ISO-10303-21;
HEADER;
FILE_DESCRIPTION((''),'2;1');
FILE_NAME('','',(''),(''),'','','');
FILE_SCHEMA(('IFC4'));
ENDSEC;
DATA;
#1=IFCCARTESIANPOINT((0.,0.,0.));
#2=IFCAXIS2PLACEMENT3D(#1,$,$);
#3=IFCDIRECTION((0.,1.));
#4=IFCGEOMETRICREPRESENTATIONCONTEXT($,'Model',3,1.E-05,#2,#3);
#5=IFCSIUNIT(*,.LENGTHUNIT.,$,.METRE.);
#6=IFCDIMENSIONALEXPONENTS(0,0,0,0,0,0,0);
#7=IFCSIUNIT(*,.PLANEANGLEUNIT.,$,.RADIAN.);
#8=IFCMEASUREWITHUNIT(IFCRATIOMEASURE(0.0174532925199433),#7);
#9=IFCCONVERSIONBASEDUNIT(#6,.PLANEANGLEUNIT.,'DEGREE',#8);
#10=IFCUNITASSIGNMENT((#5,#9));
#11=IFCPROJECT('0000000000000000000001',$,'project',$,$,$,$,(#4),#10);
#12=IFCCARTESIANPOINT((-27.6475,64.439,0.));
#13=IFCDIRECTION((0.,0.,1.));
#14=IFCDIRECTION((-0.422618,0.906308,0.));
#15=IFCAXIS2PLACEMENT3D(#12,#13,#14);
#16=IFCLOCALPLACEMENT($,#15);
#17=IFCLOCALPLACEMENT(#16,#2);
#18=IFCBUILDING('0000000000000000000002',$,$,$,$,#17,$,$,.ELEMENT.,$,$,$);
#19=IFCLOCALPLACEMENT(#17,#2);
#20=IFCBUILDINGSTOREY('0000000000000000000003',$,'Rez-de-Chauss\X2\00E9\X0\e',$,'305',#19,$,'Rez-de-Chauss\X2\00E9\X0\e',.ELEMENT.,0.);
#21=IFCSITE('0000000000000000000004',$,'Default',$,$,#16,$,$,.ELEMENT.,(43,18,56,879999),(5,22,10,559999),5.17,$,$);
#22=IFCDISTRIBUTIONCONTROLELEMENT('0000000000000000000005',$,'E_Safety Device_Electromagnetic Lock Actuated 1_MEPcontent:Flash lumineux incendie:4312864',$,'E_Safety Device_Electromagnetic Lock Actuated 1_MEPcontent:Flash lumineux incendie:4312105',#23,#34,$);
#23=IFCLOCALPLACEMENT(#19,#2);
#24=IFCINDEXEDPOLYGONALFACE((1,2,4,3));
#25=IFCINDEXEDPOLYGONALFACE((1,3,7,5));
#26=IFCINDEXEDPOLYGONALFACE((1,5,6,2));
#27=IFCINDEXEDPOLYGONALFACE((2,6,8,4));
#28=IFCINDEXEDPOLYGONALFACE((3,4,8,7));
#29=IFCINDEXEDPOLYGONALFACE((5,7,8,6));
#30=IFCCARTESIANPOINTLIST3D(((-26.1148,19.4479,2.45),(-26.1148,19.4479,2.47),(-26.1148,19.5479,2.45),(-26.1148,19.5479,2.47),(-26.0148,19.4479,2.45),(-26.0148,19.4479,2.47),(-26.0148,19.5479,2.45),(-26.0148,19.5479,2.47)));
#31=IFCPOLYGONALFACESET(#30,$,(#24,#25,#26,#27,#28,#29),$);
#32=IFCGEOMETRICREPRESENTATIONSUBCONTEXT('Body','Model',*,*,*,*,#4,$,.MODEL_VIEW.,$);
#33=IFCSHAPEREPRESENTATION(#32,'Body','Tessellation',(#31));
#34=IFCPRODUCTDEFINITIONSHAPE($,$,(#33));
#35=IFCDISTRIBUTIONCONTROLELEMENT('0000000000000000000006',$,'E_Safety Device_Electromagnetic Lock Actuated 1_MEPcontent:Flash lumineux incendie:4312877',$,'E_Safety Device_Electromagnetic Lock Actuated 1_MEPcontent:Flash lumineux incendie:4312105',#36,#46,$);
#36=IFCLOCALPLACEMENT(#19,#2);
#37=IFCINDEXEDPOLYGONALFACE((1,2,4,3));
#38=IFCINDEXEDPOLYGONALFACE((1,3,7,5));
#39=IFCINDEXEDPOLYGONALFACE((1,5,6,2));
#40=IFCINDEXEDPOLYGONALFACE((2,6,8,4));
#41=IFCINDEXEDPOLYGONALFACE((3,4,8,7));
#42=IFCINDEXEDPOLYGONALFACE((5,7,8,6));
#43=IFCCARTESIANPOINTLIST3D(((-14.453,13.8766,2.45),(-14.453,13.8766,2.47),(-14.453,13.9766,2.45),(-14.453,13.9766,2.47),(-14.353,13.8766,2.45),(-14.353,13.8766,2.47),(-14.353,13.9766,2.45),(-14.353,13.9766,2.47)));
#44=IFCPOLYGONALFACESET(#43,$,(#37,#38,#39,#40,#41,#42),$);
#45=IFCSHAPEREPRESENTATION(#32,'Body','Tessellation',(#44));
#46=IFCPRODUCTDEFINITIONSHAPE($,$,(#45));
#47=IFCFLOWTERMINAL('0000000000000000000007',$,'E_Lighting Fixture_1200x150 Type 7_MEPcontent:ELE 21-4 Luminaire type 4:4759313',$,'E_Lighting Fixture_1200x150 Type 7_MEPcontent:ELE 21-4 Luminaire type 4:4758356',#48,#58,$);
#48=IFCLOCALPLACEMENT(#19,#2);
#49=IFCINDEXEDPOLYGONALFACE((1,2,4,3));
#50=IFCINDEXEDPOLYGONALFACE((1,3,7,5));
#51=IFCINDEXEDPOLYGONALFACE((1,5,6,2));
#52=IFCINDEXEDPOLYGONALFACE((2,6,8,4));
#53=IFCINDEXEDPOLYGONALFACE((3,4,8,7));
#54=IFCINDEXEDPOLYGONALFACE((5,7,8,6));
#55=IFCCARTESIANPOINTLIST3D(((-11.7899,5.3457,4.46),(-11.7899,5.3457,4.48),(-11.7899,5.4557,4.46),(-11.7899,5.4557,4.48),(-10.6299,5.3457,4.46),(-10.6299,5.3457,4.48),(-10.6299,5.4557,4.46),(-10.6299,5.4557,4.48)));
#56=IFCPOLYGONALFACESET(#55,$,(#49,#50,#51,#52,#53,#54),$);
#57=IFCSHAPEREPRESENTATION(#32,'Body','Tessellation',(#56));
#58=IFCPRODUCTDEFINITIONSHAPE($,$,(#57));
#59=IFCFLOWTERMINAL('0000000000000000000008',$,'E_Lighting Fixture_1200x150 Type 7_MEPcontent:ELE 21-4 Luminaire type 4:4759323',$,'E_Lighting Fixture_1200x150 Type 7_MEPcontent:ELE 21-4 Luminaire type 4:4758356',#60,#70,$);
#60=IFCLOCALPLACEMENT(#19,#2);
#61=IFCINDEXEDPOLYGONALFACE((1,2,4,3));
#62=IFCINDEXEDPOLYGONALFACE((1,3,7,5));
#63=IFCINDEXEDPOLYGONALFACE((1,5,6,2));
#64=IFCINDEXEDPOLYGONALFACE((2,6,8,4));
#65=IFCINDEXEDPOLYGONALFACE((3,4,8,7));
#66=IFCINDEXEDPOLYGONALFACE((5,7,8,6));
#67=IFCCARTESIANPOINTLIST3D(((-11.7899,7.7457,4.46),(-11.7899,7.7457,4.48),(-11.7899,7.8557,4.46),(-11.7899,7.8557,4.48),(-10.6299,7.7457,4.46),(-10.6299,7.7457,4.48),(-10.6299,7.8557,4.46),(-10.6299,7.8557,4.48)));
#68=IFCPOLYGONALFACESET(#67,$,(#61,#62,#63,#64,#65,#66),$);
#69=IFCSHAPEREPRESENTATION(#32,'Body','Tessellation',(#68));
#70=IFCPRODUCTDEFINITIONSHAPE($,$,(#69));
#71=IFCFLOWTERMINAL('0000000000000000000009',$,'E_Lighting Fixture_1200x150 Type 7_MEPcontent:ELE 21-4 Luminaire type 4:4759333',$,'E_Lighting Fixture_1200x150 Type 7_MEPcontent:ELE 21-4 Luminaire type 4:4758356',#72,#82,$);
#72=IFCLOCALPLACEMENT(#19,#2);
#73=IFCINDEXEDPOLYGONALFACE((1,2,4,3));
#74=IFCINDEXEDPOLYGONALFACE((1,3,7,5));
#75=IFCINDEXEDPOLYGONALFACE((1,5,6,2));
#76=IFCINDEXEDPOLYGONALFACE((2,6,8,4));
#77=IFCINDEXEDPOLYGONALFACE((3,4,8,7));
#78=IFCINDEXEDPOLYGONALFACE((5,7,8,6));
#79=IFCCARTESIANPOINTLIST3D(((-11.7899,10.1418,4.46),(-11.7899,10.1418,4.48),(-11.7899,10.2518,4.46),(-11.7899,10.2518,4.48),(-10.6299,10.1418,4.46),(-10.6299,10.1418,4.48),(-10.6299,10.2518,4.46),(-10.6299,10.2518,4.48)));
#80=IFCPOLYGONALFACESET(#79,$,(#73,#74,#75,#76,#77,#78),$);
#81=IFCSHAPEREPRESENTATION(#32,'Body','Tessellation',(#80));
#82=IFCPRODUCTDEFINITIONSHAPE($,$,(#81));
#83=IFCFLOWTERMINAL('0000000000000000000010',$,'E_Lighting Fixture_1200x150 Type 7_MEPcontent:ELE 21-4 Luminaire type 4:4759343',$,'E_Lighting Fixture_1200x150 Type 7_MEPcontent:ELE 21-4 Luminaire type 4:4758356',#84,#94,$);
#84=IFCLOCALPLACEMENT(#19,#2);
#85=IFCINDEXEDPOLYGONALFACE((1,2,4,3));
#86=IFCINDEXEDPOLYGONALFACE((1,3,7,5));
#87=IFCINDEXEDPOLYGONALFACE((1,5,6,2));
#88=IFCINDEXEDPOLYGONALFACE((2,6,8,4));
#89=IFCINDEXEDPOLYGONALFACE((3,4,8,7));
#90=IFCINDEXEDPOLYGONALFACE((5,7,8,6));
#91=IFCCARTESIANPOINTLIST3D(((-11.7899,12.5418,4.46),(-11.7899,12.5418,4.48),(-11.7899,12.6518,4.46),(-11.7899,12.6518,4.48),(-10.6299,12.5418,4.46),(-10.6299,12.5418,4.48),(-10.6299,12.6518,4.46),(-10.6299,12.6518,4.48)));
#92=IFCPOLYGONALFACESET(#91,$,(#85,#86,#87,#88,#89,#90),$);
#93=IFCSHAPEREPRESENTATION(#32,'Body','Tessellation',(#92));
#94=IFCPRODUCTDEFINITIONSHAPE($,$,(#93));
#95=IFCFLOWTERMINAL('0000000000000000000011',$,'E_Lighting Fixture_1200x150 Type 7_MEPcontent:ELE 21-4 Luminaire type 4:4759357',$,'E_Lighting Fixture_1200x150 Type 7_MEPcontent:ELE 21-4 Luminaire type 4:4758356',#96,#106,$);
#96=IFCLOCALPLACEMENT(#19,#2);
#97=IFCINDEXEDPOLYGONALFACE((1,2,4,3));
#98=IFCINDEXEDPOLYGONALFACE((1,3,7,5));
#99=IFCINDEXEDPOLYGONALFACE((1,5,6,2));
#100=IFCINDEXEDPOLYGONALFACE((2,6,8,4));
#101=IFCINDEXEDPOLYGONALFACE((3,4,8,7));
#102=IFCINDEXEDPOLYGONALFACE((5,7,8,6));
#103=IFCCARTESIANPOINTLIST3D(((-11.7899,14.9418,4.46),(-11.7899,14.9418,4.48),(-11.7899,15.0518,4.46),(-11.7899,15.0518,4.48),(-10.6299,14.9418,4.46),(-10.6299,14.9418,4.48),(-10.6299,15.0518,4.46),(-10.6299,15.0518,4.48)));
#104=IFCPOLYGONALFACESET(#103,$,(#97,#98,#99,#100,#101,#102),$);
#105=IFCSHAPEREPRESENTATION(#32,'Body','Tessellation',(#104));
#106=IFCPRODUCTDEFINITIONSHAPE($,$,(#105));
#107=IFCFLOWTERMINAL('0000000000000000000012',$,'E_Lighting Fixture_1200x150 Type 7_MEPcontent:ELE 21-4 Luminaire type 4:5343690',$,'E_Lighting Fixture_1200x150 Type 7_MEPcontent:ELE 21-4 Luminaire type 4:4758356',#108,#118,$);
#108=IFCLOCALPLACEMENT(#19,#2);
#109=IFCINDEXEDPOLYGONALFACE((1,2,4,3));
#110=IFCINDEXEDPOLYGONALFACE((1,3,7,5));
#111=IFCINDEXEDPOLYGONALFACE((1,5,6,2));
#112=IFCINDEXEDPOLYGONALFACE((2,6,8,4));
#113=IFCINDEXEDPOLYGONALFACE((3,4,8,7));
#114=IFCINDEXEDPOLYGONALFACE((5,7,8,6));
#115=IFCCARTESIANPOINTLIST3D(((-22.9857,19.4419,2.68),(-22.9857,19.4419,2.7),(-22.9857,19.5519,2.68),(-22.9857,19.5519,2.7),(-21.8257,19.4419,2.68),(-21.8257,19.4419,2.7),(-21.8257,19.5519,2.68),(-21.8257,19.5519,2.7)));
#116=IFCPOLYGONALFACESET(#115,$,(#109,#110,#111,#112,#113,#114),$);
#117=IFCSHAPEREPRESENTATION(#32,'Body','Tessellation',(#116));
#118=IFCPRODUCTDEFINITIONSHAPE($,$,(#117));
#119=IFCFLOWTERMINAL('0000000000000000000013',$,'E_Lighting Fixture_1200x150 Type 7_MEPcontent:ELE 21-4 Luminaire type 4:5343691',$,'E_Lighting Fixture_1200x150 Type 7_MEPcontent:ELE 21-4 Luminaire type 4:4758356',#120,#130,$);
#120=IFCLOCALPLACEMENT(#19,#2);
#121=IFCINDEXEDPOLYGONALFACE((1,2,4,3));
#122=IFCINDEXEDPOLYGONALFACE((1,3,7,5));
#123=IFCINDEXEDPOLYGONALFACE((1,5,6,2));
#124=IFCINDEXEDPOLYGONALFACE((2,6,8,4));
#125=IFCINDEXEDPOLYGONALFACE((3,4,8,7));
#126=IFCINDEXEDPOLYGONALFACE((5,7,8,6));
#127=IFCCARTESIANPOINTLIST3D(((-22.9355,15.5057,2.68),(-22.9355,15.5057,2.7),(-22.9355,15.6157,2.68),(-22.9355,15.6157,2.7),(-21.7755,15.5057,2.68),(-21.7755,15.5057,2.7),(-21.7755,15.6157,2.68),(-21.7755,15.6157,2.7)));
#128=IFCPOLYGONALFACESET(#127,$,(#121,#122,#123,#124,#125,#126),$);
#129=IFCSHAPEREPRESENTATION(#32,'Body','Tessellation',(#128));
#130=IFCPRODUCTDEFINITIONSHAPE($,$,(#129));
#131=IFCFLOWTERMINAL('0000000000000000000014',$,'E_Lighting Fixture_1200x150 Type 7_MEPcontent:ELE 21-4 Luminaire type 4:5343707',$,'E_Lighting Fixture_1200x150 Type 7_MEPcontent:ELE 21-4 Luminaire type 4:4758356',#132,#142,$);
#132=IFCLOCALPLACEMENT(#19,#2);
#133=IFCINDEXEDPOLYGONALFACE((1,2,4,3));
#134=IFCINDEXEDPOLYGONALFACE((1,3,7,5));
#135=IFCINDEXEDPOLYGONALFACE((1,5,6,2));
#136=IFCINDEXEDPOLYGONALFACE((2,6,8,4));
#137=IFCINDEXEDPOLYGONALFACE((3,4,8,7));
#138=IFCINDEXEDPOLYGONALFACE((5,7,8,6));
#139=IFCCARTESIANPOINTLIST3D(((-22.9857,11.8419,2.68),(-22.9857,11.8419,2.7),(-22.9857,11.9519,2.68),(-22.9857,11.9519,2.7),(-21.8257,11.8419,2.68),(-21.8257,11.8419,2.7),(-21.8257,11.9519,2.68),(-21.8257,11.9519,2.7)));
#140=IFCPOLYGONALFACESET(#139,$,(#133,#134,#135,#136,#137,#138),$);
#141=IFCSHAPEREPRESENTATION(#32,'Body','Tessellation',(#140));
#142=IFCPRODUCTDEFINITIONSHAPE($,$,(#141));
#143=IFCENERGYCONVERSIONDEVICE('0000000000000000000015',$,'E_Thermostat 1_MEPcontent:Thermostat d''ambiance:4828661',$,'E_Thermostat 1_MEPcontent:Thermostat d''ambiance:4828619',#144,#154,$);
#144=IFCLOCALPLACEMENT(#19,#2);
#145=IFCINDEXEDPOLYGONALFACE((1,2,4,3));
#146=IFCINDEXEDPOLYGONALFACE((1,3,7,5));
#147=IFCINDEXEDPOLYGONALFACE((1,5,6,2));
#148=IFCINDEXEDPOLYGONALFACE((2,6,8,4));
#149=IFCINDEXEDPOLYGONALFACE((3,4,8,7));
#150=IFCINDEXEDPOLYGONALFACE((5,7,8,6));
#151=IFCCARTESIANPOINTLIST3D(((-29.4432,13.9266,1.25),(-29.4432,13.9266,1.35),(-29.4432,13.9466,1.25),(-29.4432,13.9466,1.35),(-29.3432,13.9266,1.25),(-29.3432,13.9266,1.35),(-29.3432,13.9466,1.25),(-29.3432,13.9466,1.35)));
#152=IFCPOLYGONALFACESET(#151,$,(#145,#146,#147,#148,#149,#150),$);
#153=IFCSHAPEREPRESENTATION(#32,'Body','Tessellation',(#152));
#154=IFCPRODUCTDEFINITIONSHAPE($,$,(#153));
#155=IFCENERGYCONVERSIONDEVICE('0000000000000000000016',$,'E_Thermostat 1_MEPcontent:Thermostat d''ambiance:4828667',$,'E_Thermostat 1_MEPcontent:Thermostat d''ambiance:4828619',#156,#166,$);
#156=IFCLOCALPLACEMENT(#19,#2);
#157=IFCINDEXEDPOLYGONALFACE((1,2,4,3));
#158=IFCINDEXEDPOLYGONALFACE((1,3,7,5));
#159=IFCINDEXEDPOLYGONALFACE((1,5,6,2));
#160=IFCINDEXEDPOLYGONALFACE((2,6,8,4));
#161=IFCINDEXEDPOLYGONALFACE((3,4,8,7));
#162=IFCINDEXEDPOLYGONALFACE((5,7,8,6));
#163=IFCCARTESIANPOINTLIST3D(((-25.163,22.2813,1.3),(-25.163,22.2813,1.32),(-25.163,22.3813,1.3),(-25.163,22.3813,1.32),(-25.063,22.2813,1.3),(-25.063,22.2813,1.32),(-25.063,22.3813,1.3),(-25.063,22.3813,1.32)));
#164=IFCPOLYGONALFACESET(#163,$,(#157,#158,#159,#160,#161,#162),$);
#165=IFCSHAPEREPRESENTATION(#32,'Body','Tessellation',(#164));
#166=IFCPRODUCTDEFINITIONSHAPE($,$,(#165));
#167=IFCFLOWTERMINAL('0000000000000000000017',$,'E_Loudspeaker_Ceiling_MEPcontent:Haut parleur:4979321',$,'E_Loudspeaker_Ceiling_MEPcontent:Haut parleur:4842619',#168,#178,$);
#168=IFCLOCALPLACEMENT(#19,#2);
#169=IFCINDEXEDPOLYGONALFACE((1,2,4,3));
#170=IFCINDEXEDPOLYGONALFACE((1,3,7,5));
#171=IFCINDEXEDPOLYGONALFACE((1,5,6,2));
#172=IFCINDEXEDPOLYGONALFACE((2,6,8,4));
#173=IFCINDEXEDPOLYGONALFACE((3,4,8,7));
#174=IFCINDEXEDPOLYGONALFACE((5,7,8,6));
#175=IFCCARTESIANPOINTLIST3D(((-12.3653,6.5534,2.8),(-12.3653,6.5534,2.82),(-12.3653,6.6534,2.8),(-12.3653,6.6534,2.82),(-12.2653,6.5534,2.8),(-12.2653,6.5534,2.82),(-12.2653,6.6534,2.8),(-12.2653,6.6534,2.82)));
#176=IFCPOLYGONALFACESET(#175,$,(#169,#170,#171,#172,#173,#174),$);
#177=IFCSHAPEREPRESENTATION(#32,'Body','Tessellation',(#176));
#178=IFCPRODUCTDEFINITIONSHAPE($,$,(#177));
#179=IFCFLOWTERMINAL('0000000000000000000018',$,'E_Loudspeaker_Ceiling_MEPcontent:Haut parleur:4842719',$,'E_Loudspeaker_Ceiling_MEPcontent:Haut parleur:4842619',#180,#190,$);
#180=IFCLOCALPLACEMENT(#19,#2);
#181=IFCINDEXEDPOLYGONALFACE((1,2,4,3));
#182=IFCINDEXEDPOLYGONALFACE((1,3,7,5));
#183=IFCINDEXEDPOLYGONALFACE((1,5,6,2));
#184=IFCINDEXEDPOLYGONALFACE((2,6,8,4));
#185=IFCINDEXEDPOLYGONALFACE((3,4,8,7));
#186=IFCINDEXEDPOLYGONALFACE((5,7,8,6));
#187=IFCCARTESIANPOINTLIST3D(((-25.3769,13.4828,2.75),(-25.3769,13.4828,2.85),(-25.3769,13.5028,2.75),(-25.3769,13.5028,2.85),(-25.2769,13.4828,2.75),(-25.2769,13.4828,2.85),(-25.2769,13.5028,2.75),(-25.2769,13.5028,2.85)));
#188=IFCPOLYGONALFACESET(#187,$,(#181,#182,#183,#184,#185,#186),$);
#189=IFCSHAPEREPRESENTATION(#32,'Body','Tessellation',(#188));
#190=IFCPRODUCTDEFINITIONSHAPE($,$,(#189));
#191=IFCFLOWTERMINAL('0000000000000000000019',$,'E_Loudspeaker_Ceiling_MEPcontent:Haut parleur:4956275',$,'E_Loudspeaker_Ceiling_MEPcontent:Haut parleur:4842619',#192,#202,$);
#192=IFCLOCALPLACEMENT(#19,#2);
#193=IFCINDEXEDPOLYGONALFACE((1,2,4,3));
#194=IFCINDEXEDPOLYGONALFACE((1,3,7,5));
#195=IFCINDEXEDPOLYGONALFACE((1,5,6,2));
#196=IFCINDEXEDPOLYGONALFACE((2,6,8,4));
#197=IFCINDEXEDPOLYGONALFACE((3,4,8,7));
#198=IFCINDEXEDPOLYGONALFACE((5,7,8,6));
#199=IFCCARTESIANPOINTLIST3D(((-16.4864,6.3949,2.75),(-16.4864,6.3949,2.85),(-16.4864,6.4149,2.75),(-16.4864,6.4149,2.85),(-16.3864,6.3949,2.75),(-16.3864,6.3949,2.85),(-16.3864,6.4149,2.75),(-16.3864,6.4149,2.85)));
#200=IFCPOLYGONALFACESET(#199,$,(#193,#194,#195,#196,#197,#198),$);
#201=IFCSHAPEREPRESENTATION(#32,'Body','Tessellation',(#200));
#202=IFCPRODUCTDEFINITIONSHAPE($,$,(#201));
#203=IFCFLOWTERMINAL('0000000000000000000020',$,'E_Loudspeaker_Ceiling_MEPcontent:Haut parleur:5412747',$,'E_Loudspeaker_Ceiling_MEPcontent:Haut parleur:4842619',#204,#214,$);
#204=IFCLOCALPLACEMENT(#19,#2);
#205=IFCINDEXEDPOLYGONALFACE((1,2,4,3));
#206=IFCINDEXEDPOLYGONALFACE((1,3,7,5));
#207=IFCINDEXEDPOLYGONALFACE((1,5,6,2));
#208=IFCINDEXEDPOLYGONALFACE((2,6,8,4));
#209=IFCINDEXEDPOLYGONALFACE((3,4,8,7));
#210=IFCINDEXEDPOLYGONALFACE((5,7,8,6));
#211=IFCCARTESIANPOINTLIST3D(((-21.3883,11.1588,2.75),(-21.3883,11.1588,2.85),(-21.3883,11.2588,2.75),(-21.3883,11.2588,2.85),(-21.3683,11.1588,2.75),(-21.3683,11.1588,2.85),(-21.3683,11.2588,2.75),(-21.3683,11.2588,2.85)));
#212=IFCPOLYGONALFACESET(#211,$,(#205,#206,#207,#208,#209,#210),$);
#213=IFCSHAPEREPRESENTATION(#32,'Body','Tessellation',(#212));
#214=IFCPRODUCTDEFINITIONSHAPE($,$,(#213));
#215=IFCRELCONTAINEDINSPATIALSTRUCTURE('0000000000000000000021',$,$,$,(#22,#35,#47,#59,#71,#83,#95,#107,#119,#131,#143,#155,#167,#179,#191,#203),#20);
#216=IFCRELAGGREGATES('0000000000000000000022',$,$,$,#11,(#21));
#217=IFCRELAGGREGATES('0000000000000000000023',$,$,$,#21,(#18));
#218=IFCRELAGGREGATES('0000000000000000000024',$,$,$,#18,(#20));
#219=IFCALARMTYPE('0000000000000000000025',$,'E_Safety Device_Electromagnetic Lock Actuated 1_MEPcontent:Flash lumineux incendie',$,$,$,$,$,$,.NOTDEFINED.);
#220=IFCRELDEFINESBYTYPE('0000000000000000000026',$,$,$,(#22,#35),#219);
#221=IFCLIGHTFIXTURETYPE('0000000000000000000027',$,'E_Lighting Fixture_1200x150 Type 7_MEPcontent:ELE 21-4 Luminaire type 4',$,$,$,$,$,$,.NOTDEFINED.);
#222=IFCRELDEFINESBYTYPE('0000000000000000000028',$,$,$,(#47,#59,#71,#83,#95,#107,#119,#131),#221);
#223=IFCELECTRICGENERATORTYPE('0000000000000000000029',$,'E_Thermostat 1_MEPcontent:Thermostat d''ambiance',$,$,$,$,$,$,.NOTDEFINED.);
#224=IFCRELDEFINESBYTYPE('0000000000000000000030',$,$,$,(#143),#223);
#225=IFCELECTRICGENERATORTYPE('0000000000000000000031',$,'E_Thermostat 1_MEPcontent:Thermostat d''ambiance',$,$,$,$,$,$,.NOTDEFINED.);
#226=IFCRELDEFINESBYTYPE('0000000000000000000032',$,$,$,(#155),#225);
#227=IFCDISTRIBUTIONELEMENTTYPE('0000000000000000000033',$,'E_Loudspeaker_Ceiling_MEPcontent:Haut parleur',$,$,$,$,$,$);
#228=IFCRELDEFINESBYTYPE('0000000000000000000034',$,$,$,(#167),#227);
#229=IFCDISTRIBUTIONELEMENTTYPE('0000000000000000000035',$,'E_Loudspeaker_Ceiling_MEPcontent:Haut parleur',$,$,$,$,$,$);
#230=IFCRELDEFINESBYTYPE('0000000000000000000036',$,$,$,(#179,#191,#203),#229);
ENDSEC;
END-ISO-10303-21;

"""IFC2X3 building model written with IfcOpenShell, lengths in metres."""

from ifc_helpers import new_model, entity, si_unit, converted_unit, direction, frame, frame_2d, origin, origin_2d_with_axis, place, context, subcontext, project, spatial, rectangle, extrude, source, transform, mapped, type_object, type_shapes, element, save


model = new_model("IFC2X3")

# Units and contexts
model_context = context("Model", 3, precision=1e-05, world=origin(), true_north=direction((0.0, 1.0)))
body_context = subcontext(model_context, "Body", "Model", "MODEL_VIEW")
ifc_project = project(units=[si_unit("LENGTHUNIT", "METRE"), converted_unit("PLANEANGLEUNIT", "DEGREE", entity("IfcRatioMeasure", 0.0174532925199433), si_unit("PLANEANGLEUNIT", "RADIAN"), dimensions=[0, 0, 0, 0, 0, 0, 0])], contexts=[model_context])

# Site, building, storey
site_placement = place(None, frame((-27.6475, 64.439, 0.0), z_axis=(0.0, 0.0, 1.0), x_axis=(-0.422618, 0.906308, 0.0)))
site = spatial("IfcSite", under=ifc_project, at=site_placement, Name="Default", CompositionType="ELEMENT", RefLatitude=(43, 18, 56, 879999), RefLongitude=(5, 22, 10, 559999), RefElevation=5.17)
building_placement = place(site_placement, origin())
building = spatial("IfcBuilding", under=site, at=building_placement, CompositionType="ELEMENT")
storey_placement = place(building_placement, origin())
storey = spatial("IfcBuildingStorey", under=building, at=storey_placement, Name="Rez-de-Chaussée", ObjectType="305", LongName="Rez-de-Chaussée", CompositionType="ELEMENT", Elevation=0.0)

# Distribution control elements
alarm_type = type_object("IfcAlarmType", Name="E_Safety Device_Electromagnetic Lock Actuated 1_MEPcontent:Flash lumineux incendie", PredefinedType="NOTDEFINED")
shared_shape_1 = source(origin(), body_context, "Body", "SweptSolid", [
    extrude(rectangle(XDim=0.1, YDim=0.1, at=origin_2d_with_axis()), frame((0.0, 0.0, 0.0), z_axis=(0.0, 0.0, 1.0), x_axis=(0.0, -1.0, 0.0)), (0.0, 0.0, 1.0), 0.02),
])
type_shapes(alarm_type, [shared_shape_1])
for number, where, z_axis, x_axis, name in (
    (1, (-26.0648, 19.4979, 2.45), (0.0, 0.0, 1.0), (0.0, -1.0, 0.0), "E_Safety Device_Electromagnetic Lock Actuated 1_MEPcontent:Flash lumineux incendie:4312864"),
    (2, (-14.403, 13.9266, 2.45), (0.0, 0.0, 1.0), (0.0, -1.0, 0.0), "E_Safety Device_Electromagnetic Lock Actuated 1_MEPcontent:Flash lumineux incendie:4312877"),
):
    element("IfcDistributionControlElement", number, at=place(storey_placement, frame(where, z_axis=z_axis, x_axis=x_axis)), inside=storey, type_object=alarm_type, Name=name, ObjectType="E_Safety Device_Electromagnetic Lock Actuated 1_MEPcontent:Flash lumineux incendie:4312105", context=body_context, shape_type="MappedRepresentation", body=[
        mapped(shared_shape_1, transform((0.0, 0.0, 0.0), scale=1.0)),
    ])

# Flow terminals
light_fixture_type_1 = type_object("IfcLightFixtureType", Name="E_Lighting Fixture_1200x150 Type 7_MEPcontent:ELE 21-4 Luminaire type 4", PredefinedType="NOTDEFINED")
shared_shape_2 = source(origin(), body_context, "Body", "SweptSolid", [
    extrude(rectangle(XDim=0.11, YDim=1.16, at=origin_2d_with_axis()), frame((0.0, 0.0, 0.0), z_axis=(0.0, 0.0, 1.0), x_axis=(0.0, -1.0, 0.0)), (0.0, 0.0, 1.0), 0.02),
])
type_shapes(light_fixture_type_1, [shared_shape_2])
for number, where, name in (
    (3, (-11.2099, 5.4007, 4.46), "E_Lighting Fixture_1200x150 Type 7_MEPcontent:ELE 21-4 Luminaire type 4:4759313"),
    (4, (-11.2099, 7.8007, 4.46), "E_Lighting Fixture_1200x150 Type 7_MEPcontent:ELE 21-4 Luminaire type 4:4759323"),
    (5, (-11.2099, 10.1968, 4.46), "E_Lighting Fixture_1200x150 Type 7_MEPcontent:ELE 21-4 Luminaire type 4:4759333"),
    (6, (-11.2099, 12.5968, 4.46), "E_Lighting Fixture_1200x150 Type 7_MEPcontent:ELE 21-4 Luminaire type 4:4759343"),
    (7, (-11.2099, 14.9968, 4.46), "E_Lighting Fixture_1200x150 Type 7_MEPcontent:ELE 21-4 Luminaire type 4:4759357"),
    (8, (-22.4057, 19.4969, 2.68), "E_Lighting Fixture_1200x150 Type 7_MEPcontent:ELE 21-4 Luminaire type 4:5343690"),
    (9, (-22.3555, 15.5607, 2.68), "E_Lighting Fixture_1200x150 Type 7_MEPcontent:ELE 21-4 Luminaire type 4:5343691"),
    (10, (-22.4057, 11.8969, 2.68), "E_Lighting Fixture_1200x150 Type 7_MEPcontent:ELE 21-4 Luminaire type 4:5343707"),
):
    element("IfcFlowTerminal", number, at=place(storey_placement, frame(where)), inside=storey, type_object=light_fixture_type_1, Name=name, ObjectType="E_Lighting Fixture_1200x150 Type 7_MEPcontent:ELE 21-4 Luminaire type 4:4758356", context=body_context, shape_type="MappedRepresentation", body=[
        mapped(shared_shape_2, transform((0.0, 0.0, 0.0), scale=1.0)),
    ])

# Energy conversion devices
electric_generator_type_1 = type_object("IfcElectricGeneratorType", Name="E_Thermostat 1_MEPcontent:Thermostat d'ambiance", PredefinedType="NOTDEFINED")
shared_shape_3 = source(origin(), body_context, "Body", "SweptSolid", [
    extrude(rectangle(XDim=0.02, YDim=0.1, at=frame_2d((0.0, 0.0), x_axis=(1.0, 0.0))), frame((0.0, 0.01, -0.05), z_axis=(0.0, 0.0, 1.0), x_axis=(0.0, -1.0, 0.0)), (0.0, 0.0, 1.0), 0.1),
])
type_shapes(electric_generator_type_1, [shared_shape_3])
energy_conversion_device_1_placement = place(storey_placement, frame((-29.3932, 13.9266, 1.3)))
element("IfcEnergyConversionDevice", 11, at=energy_conversion_device_1_placement, inside=storey, type_object=electric_generator_type_1, Name="E_Thermostat 1_MEPcontent:Thermostat d'ambiance:4828661", ObjectType="E_Thermostat 1_MEPcontent:Thermostat d'ambiance:4828619", context=body_context, shape_type="MappedRepresentation", body=[
    mapped(shared_shape_3, transform((0.0, 0.0, 0.0), scale=1.0)),
])
electric_generator_type_2 = type_object("IfcElectricGeneratorType", Name="E_Thermostat 1_MEPcontent:Thermostat d'ambiance", PredefinedType="NOTDEFINED")
shared_shape_4 = source(origin(), body_context, "Body", "SweptSolid", [
    extrude(rectangle(XDim=0.1, YDim=0.1, at=origin_2d_with_axis()), frame((0.0, 0.0, 0.0), z_axis=(0.0, 0.0, 1.0), x_axis=(0.0, -1.0, 0.0)), (0.0, 0.0, 1.0), 0.02),
])
type_shapes(electric_generator_type_2, [shared_shape_4])
energy_conversion_device_2_placement = place(storey_placement, frame((-25.113, 22.3313, 1.3)))
element("IfcEnergyConversionDevice", 12, at=energy_conversion_device_2_placement, inside=storey, type_object=electric_generator_type_2, Name="E_Thermostat 1_MEPcontent:Thermostat d'ambiance:4828667", ObjectType="E_Thermostat 1_MEPcontent:Thermostat d'ambiance:4828619", context=body_context, shape_type="MappedRepresentation", body=[
    mapped(shared_shape_4, transform((0.0, 0.0, 0.0), scale=1.0)),
])

# Flow terminals
distribution_element_type_1 = type_object("IfcDistributionElementType", Name="E_Loudspeaker_Ceiling_MEPcontent:Haut parleur")
shared_shape_5 = source(origin(), body_context, "Body", "SweptSolid", [
    extrude(rectangle(XDim=0.1, YDim=0.1, at=origin_2d_with_axis()), frame((0.0, 0.0, 0.0), z_axis=(0.0, 0.0, 1.0), x_axis=(0.0, -1.0, 0.0)), (0.0, 0.0, 1.0), 0.02),
])
type_shapes(distribution_element_type_1, [shared_shape_5])
flow_terminal_1_placement = place(storey_placement, frame((-12.3153, 6.6034, 2.8), z_axis=(0.0, 0.0, 1.0), x_axis=(0.0, -1.0, 0.0)))
element("IfcFlowTerminal", 13, at=flow_terminal_1_placement, inside=storey, type_object=distribution_element_type_1, Name="E_Loudspeaker_Ceiling_MEPcontent:Haut parleur:4979321", ObjectType="E_Loudspeaker_Ceiling_MEPcontent:Haut parleur:4842619", context=body_context, shape_type="MappedRepresentation", body=[
    mapped(shared_shape_5, transform((0.0, 0.0, 0.0), scale=1.0)),
])
distribution_element_type_2 = type_object("IfcDistributionElementType", Name="E_Loudspeaker_Ceiling_MEPcontent:Haut parleur")
shared_shape_6 = source(origin(), body_context, "Body", "SweptSolid", [
    extrude(rectangle(XDim=0.02, YDim=0.1, at=frame_2d((0.0, 0.0), x_axis=(1.0, 0.0))), frame((0.0, 0.01, -0.05), z_axis=(0.0, 0.0, 1.0), x_axis=(0.0, -1.0, 0.0)), (0.0, 0.0, 1.0), 0.1),
])
type_shapes(distribution_element_type_2, [shared_shape_6])
for number, where, z_axis, x_axis, name in (
    (14, (-25.3269, 13.5028, 2.8), (0.0, 0.0, 1.0), (-1.0, 0.0, 0.0), "E_Loudspeaker_Ceiling_MEPcontent:Haut parleur:4842719"),
    (15, (-16.4364, 6.4149, 2.8), (0.0, 0.0, 1.0), (-1.0, 0.0, 0.0), "E_Loudspeaker_Ceiling_MEPcontent:Haut parleur:4956275"),
    (16, (-21.3883, 11.2088, 2.8), (0.0, 0.0, 1.0), (0.0, -1.0, 0.0), "E_Loudspeaker_Ceiling_MEPcontent:Haut parleur:5412747"),
):
    element("IfcFlowTerminal", number, at=place(storey_placement, frame(where, z_axis=z_axis, x_axis=x_axis)), inside=storey, type_object=distribution_element_type_2, Name=name, ObjectType="E_Loudspeaker_Ceiling_MEPcontent:Haut parleur:4842619", context=body_context, shape_type="MappedRepresentation", body=[
        mapped(shared_shape_6, transform((0.0, 0.0, 0.0), scale=1.0)),
    ])

save(model, "model.ifc")
